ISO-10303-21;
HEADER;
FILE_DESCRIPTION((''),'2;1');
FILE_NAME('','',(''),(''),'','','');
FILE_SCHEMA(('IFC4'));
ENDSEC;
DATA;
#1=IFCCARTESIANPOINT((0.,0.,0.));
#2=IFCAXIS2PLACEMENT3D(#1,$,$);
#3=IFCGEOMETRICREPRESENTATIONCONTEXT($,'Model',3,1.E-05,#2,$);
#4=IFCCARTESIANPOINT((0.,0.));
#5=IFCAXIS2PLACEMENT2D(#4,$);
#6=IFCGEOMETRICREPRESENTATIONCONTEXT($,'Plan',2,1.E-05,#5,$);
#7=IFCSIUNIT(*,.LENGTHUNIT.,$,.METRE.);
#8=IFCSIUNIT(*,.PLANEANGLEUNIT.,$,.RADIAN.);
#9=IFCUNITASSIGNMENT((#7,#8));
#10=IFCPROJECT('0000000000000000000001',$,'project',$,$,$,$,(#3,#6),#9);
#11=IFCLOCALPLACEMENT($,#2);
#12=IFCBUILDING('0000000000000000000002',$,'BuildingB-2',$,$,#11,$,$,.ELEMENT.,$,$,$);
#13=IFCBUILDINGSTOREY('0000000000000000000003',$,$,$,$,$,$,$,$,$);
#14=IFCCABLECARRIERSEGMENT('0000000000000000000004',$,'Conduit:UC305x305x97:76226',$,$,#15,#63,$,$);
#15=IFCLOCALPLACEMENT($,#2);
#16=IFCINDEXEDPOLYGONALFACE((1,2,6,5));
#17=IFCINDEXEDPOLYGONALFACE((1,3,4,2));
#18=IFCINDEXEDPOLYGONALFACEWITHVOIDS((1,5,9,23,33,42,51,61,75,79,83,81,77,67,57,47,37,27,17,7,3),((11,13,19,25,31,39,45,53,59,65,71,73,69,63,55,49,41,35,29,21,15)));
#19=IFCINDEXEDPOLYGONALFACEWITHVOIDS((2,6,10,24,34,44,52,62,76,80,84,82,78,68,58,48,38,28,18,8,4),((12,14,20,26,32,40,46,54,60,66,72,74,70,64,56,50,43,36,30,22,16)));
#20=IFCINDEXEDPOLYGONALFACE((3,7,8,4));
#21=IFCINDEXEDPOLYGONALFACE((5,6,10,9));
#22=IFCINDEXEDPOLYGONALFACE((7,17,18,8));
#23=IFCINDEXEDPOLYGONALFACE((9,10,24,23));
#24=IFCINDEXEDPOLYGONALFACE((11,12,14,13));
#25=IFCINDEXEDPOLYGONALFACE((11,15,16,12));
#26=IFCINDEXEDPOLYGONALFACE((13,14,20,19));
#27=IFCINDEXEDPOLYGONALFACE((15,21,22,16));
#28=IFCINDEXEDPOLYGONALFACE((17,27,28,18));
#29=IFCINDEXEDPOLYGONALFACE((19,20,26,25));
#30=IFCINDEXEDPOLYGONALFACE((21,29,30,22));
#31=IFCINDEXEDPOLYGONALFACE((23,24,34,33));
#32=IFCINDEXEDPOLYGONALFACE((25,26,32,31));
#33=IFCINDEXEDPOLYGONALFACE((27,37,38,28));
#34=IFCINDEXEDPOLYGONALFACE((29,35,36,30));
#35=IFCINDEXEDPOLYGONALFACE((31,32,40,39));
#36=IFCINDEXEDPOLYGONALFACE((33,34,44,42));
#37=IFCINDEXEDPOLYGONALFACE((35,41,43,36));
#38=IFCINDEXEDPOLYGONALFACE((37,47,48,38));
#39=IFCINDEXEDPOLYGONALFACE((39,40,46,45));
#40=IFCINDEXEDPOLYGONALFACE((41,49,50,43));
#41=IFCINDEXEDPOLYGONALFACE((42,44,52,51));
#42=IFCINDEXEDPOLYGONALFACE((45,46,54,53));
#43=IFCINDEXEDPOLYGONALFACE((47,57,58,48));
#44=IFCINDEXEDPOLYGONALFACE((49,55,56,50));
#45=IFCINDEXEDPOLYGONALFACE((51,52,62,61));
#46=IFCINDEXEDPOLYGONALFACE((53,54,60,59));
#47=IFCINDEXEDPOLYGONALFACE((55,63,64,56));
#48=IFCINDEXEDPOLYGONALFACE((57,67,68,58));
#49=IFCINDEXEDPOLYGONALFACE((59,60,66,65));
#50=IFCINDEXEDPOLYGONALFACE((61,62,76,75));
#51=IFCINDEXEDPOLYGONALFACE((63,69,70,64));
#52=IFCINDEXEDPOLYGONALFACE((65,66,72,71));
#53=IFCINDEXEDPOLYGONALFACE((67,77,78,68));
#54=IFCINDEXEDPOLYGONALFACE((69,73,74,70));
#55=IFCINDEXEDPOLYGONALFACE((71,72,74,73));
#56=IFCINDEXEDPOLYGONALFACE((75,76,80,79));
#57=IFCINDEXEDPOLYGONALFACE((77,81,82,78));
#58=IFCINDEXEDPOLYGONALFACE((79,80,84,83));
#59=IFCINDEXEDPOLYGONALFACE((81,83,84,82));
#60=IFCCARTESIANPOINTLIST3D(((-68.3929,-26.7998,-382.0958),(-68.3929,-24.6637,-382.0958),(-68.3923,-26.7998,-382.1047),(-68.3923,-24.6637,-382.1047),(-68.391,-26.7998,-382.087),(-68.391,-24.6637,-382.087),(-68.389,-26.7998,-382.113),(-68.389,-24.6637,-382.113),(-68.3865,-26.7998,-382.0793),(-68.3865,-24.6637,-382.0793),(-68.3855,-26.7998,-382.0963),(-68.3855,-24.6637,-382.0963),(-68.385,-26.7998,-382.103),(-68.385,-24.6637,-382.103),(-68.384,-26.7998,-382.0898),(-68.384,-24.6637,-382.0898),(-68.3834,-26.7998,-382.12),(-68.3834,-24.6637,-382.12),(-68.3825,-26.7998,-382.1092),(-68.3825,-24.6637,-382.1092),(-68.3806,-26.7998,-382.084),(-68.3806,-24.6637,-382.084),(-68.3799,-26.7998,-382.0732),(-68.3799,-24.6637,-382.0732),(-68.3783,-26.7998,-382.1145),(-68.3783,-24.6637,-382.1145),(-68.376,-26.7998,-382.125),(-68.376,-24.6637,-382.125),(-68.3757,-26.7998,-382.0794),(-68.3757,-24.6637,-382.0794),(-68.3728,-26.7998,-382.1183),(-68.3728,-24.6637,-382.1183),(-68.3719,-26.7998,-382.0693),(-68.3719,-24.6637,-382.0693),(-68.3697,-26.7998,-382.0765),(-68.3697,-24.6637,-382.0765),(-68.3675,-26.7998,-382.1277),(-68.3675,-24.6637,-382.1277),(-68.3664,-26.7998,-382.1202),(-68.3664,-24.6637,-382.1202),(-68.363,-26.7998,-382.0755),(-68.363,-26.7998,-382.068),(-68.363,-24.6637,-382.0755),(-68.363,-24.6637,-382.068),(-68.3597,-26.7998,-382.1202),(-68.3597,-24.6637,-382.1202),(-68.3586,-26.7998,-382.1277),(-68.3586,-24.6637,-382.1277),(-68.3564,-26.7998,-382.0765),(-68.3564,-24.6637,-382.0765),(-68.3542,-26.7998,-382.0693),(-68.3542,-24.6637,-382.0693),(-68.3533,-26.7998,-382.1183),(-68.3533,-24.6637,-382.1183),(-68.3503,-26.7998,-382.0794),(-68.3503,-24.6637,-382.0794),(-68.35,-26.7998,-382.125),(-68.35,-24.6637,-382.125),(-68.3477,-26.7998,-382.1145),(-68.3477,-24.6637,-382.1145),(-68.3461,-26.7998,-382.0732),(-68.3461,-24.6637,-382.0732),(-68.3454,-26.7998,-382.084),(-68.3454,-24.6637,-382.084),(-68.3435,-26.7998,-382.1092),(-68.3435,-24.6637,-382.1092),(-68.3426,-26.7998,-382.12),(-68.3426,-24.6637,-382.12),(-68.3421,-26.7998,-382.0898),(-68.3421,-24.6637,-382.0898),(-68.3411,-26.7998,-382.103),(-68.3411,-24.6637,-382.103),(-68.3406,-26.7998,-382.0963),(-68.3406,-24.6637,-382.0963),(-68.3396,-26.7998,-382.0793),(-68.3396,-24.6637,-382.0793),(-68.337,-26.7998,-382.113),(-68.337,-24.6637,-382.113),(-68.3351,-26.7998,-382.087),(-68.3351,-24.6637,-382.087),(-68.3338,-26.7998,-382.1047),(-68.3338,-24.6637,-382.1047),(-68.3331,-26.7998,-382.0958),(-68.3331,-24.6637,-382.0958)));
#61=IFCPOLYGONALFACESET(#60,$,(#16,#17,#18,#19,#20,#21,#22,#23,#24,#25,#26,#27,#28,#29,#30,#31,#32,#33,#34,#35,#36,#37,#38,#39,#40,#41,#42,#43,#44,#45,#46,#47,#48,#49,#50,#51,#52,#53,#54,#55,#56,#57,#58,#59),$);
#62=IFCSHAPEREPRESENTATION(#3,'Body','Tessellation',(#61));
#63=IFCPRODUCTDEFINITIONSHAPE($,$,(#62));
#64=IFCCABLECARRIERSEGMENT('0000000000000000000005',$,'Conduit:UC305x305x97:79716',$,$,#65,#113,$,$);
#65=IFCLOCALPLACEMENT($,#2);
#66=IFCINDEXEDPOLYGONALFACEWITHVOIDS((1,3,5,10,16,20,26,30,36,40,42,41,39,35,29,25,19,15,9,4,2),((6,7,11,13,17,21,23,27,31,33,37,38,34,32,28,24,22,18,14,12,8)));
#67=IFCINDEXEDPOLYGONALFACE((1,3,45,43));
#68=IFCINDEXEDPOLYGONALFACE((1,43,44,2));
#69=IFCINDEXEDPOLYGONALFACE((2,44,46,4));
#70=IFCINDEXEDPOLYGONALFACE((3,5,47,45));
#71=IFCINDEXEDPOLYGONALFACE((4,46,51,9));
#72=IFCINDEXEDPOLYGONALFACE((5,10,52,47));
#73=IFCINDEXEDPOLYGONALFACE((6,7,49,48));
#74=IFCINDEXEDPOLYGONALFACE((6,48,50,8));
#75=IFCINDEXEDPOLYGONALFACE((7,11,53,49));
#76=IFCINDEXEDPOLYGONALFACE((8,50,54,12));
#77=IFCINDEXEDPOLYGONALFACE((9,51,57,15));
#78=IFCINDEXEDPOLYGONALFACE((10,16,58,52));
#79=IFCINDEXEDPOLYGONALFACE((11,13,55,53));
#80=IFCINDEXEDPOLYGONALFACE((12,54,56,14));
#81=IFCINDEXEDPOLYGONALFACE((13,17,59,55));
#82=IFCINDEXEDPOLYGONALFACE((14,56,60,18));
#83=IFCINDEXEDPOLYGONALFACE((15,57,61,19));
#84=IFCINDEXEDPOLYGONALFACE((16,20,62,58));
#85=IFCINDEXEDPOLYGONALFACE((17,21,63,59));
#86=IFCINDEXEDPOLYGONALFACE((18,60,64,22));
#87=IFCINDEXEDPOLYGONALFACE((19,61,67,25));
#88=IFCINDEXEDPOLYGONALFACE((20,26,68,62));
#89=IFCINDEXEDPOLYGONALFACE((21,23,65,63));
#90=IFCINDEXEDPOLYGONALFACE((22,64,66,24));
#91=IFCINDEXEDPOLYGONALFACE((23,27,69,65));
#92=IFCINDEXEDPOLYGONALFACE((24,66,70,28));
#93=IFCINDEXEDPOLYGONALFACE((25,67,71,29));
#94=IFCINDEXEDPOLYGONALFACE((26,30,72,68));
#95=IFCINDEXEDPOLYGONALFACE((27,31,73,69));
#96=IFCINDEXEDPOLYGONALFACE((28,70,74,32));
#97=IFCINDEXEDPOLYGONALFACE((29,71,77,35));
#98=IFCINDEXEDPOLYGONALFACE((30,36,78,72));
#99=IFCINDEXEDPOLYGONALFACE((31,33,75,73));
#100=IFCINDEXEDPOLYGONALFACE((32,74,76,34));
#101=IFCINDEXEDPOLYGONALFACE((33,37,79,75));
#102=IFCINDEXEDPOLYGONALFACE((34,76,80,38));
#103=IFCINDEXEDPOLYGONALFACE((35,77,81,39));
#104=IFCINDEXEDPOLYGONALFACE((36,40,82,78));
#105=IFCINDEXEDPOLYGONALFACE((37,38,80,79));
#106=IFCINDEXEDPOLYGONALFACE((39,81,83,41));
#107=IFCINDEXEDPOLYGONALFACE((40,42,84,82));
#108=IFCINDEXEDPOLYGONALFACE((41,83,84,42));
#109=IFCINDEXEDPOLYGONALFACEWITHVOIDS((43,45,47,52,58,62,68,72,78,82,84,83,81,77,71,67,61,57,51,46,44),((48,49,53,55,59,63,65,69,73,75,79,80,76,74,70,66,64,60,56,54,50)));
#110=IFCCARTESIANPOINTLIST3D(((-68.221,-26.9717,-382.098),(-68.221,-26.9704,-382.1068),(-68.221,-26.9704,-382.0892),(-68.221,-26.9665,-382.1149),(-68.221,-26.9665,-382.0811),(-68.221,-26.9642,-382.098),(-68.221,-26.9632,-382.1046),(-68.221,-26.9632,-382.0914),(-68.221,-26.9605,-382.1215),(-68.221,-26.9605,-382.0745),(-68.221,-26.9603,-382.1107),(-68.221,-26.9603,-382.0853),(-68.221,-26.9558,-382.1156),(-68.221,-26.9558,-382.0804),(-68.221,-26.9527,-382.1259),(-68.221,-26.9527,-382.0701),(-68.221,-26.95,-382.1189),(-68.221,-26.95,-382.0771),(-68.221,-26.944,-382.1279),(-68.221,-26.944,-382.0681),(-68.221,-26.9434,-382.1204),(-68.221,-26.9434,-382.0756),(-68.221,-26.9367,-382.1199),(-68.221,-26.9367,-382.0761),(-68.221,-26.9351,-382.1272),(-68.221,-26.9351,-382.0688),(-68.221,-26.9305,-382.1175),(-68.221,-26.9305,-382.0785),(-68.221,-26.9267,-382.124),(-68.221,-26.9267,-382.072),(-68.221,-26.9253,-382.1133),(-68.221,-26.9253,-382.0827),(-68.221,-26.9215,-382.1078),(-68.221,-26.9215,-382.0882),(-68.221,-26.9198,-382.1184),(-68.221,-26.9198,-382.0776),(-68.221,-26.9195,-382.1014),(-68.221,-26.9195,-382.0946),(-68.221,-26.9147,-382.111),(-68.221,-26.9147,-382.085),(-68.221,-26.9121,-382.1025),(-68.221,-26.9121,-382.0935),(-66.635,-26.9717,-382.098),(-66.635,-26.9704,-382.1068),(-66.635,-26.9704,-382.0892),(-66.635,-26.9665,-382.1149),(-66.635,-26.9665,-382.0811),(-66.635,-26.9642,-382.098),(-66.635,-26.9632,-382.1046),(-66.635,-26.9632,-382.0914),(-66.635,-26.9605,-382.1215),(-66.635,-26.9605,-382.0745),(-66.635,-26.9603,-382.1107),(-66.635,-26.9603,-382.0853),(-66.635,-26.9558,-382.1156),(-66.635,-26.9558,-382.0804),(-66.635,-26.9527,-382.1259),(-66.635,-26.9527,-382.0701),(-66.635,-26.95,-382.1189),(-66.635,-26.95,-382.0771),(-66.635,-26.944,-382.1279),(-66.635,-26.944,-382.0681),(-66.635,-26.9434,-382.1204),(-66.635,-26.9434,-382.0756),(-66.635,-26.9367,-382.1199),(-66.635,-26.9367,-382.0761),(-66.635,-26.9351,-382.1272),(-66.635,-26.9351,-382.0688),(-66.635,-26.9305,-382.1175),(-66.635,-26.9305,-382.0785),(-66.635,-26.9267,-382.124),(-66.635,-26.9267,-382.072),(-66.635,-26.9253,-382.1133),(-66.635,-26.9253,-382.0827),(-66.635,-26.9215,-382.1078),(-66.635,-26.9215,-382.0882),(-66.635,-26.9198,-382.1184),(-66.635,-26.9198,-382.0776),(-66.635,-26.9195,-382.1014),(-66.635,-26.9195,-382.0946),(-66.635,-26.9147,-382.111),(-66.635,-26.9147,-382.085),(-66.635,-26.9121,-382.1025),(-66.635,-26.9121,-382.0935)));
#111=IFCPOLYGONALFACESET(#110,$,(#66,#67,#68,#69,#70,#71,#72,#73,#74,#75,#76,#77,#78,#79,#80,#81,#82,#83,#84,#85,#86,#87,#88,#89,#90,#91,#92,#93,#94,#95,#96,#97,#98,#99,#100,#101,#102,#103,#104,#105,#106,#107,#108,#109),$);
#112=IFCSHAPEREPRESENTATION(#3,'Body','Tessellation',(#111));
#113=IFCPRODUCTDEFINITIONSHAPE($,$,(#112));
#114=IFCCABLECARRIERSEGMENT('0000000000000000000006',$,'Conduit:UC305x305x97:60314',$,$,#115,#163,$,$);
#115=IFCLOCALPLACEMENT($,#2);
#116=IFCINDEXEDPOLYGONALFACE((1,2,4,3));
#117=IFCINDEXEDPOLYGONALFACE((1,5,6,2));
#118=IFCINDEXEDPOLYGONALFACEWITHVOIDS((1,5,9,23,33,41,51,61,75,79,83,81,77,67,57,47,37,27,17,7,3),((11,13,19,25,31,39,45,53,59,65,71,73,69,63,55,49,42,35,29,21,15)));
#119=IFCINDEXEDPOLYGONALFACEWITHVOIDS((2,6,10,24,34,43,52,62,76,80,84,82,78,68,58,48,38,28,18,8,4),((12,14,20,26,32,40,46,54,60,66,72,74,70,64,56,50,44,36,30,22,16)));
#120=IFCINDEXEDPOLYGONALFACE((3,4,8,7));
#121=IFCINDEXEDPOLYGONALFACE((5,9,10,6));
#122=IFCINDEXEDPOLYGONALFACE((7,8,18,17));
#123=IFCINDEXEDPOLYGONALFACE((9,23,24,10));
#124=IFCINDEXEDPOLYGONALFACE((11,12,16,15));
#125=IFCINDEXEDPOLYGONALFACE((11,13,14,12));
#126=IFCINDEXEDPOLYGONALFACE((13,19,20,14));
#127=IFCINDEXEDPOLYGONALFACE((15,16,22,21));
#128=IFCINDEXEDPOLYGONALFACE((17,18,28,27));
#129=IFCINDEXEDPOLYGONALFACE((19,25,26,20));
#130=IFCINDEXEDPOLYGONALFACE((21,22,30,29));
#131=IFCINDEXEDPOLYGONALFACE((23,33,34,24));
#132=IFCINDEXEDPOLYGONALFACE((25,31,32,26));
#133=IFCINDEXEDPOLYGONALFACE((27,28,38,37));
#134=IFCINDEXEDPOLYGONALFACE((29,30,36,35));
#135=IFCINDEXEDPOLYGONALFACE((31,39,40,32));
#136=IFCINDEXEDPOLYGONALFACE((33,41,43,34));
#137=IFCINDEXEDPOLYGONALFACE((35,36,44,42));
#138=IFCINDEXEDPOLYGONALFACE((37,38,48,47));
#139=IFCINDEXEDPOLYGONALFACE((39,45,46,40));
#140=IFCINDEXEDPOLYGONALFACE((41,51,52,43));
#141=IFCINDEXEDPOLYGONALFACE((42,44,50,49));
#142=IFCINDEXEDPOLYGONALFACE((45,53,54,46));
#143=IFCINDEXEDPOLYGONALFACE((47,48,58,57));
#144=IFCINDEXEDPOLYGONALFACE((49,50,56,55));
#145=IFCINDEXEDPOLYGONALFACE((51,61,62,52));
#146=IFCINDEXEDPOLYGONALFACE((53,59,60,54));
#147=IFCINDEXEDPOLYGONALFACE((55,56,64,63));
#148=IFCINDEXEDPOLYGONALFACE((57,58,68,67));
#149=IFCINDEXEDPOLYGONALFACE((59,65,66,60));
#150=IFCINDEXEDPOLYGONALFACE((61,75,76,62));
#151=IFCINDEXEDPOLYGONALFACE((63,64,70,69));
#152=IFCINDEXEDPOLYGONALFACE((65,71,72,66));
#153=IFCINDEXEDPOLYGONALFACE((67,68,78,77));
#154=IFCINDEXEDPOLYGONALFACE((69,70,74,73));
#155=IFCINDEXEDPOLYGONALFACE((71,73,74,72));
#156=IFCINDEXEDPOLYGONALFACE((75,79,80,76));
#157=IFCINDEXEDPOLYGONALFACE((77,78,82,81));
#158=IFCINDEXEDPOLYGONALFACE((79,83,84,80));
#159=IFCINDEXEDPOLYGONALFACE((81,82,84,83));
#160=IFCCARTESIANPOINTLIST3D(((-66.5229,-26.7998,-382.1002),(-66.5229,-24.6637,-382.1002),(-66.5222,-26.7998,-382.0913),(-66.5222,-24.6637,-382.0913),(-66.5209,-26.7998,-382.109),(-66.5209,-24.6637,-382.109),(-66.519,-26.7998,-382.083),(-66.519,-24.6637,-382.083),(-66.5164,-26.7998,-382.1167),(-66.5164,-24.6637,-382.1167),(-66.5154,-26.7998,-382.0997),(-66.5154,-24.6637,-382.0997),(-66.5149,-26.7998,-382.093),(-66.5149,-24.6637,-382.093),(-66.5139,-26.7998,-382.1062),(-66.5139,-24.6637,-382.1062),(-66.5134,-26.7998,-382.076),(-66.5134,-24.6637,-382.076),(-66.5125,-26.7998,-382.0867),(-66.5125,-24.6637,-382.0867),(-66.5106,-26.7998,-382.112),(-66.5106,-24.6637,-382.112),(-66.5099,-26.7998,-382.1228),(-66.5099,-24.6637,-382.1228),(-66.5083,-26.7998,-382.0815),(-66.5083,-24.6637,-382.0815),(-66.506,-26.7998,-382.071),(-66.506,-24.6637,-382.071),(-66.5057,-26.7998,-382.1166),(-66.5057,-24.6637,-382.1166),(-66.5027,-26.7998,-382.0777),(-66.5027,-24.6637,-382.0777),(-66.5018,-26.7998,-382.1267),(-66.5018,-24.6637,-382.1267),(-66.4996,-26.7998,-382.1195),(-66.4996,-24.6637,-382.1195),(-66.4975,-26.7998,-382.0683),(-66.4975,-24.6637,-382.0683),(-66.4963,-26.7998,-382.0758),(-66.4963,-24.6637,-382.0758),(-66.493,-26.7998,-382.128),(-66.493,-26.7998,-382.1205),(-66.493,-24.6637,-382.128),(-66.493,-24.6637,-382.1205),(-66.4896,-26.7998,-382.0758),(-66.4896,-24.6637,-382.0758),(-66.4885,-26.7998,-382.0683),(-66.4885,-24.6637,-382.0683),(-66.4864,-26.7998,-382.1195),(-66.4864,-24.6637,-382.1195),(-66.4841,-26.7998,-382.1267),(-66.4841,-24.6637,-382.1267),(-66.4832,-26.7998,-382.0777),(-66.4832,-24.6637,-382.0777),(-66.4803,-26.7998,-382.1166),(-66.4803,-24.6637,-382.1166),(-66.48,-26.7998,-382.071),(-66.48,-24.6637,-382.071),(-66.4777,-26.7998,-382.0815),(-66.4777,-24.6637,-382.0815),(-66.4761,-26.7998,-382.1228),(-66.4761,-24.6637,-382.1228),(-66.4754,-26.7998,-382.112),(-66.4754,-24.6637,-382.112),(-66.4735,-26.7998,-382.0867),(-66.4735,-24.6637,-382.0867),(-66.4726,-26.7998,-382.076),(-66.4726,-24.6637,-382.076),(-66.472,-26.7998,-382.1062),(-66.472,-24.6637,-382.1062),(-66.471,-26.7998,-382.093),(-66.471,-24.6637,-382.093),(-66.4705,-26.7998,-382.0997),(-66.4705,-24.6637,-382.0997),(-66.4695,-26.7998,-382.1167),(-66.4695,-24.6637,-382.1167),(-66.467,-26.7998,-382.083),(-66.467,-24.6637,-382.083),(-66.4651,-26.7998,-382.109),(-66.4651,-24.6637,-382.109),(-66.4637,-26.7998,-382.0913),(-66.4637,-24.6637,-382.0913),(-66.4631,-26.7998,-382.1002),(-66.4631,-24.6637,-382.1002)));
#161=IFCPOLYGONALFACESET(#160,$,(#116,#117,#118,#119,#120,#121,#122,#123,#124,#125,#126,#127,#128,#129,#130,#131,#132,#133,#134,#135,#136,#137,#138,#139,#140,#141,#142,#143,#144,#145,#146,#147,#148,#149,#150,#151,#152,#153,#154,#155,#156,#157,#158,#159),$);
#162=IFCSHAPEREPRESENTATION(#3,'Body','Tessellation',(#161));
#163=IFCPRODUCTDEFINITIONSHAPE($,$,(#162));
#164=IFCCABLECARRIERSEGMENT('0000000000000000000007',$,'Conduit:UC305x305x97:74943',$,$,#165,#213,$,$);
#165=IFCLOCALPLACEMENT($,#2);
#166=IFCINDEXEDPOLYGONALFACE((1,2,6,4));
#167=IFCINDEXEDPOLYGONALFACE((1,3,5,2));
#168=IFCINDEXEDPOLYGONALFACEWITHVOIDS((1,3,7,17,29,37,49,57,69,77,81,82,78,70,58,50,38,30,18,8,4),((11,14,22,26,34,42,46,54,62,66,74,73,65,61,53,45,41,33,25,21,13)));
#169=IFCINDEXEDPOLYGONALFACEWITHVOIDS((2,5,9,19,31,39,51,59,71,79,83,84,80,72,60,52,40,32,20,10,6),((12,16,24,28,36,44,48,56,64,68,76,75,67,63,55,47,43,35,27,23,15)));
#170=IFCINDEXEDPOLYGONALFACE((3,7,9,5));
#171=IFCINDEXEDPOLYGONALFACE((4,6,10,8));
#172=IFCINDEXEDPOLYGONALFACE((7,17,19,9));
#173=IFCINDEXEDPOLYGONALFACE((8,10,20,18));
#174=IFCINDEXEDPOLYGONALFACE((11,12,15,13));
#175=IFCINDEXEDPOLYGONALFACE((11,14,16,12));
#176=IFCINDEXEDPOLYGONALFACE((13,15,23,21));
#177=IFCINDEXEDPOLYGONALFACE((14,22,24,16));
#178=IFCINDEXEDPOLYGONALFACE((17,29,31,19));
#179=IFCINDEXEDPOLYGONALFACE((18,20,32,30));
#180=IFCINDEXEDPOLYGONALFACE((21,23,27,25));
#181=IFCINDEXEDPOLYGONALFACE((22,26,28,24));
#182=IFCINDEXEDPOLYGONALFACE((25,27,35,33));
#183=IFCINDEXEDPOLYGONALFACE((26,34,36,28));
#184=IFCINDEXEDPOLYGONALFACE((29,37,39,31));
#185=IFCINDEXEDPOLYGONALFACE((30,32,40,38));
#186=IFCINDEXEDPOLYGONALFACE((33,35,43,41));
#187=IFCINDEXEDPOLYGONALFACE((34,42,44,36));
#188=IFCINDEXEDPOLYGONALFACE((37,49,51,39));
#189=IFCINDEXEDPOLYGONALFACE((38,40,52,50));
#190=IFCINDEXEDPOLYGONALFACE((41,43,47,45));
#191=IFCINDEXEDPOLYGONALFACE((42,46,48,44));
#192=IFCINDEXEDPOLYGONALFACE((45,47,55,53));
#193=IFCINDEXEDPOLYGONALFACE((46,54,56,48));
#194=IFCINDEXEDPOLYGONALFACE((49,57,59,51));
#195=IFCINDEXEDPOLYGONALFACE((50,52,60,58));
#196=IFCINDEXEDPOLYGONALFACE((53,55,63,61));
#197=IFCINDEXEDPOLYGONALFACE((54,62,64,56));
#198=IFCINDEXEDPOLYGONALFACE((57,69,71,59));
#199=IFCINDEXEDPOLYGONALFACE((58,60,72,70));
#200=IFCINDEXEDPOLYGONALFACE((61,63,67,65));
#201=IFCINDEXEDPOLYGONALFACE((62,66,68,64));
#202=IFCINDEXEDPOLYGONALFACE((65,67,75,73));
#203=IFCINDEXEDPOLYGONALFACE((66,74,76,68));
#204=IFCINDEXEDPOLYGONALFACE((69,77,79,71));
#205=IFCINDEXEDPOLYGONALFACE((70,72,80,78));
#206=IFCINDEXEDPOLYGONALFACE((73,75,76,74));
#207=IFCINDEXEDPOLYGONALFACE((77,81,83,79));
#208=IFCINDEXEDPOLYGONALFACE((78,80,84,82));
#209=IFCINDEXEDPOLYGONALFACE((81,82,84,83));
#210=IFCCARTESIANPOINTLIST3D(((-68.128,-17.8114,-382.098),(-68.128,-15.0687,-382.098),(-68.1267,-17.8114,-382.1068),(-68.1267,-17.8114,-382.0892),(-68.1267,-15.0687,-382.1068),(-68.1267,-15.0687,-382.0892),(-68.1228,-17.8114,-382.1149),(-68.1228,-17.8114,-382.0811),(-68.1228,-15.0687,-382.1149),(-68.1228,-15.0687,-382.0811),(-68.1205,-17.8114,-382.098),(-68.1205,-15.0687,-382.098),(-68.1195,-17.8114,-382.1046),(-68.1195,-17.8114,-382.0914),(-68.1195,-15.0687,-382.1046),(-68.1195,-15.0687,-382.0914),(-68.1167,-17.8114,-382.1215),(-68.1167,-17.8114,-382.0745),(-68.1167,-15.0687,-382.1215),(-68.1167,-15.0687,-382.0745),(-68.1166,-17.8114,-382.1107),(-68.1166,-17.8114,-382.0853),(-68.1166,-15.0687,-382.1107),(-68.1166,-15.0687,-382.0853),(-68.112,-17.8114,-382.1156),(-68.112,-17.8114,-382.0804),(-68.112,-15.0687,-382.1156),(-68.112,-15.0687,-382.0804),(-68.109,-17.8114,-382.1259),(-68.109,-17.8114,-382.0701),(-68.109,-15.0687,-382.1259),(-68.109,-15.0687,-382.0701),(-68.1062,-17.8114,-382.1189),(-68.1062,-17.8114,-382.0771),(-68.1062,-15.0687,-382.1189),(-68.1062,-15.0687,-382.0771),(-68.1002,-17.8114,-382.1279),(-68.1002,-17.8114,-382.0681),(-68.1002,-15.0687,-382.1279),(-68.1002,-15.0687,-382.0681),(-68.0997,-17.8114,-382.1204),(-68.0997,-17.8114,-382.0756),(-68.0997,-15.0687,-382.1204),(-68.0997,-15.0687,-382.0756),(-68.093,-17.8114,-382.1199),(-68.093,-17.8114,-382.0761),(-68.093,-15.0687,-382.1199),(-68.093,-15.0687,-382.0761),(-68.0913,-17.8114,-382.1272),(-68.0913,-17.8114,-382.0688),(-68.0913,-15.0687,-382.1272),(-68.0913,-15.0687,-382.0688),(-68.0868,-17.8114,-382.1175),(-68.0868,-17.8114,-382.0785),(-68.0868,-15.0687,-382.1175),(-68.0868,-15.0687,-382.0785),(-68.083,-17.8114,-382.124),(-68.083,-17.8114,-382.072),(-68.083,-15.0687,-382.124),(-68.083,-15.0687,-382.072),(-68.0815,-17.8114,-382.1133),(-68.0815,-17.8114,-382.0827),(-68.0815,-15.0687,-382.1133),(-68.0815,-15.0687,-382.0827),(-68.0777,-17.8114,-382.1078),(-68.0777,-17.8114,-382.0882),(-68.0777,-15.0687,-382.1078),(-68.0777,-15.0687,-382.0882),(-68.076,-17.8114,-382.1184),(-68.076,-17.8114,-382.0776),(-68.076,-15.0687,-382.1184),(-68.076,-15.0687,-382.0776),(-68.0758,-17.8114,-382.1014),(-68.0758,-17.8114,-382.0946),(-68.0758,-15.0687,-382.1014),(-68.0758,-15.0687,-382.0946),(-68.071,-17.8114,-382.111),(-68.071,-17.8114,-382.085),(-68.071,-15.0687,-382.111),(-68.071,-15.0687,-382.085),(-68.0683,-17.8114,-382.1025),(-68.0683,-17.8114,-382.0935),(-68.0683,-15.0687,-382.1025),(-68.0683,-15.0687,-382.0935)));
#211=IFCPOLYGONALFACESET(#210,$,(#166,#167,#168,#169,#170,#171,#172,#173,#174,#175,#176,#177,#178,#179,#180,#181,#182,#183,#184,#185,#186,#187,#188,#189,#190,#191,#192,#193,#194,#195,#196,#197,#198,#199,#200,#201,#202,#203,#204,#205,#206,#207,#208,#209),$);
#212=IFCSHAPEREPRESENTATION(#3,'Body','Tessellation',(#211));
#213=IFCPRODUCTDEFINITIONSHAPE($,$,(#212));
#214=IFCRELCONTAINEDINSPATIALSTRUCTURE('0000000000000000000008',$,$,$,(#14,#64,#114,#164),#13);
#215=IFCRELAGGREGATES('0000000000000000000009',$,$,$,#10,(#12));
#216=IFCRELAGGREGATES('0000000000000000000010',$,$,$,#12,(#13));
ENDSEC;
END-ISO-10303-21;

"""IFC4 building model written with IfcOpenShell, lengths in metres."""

from ifc_helpers import new_model, entity, si_unit, origin, origin_2d, place, context, project, spatial, element, save


model = new_model("IFC4")

# Units and contexts
model_context = context("Model", 3, precision=1e-05, world=origin())
plan_context = context("Plan", 2, precision=1e-05, world=origin_2d())
ifc_project = project(units=[si_unit("LENGTHUNIT", "METRE"), si_unit("PLANEANGLEUNIT", "RADIAN")], contexts=[model_context, plan_context])

# Building, storey
building_placement = place(None, origin())
building = spatial("IfcBuilding", under=ifc_project, at=building_placement, Name="BuildingB-2", CompositionType="ELEMENT")
storey = spatial("IfcBuildingStorey", under=building)

# Cable carrier segments
element("IfcCableCarrierSegment", 1, inside=storey, Name="Conduit:UC305x305x97:76226", context=model_context, shape_type="AdvancedSweptSolid", body=[
    entity("IfcSweptDiskSolid", entity("IfcCompositeCurve", [entity("IfcCompositeCurveSegment", "CONTINUOUS", False, entity("IfcPolyline", [entity("IfcCartesianPoint", [68.363, 24.6637, 382.098]), entity("IfcCartesianPoint", [68.363, 26.7998, 382.098])]))], False), 0.03, 0.0225),
])
element("IfcCableCarrierSegment", 2, inside=storey, Name="Conduit:UC305x305x97:79716", context=model_context, shape_type="AdvancedSweptSolid", body=[
    entity("IfcSweptDiskSolid", entity("IfcCompositeCurve", [entity("IfcCompositeCurveSegment", "CONTINUOUS", False, entity("IfcPolyline", [entity("IfcCartesianPoint", [68.221, 26.9417, 382.098]), entity("IfcCartesianPoint", [66.635, 26.9417, 382.098])]))], False), 0.03, 0.0225),
])
element("IfcCableCarrierSegment", 3, inside=storey, Name="Conduit:UC305x305x97:60314", context=model_context, shape_type="AdvancedSweptSolid", body=[
    entity("IfcSweptDiskSolid", entity("IfcCompositeCurve", [entity("IfcCompositeCurveSegment", "CONTINUOUS", False, entity("IfcPolyline", [entity("IfcCartesianPoint", [66.493, 26.7998, 382.098]), entity("IfcCartesianPoint", [66.493, 24.6637, 382.098])]))], False), 0.03, 0.0225),
])
element("IfcCableCarrierSegment", 4, inside=storey, Name="Conduit:UC305x305x97:74943", context=model_context, shape_type="AdvancedSweptSolid", body=[
    entity("IfcSweptDiskSolid", entity("IfcCompositeCurve", [entity("IfcCompositeCurveSegment", "CONTINUOUS", False, entity("IfcPolyline", [entity("IfcCartesianPoint", [68.098, 17.8114, 382.098]), entity("IfcCartesianPoint", [68.098, 15.0687, 382.098])]))], False), 0.03, 0.0225),
])

save(model, "model.ifc")
